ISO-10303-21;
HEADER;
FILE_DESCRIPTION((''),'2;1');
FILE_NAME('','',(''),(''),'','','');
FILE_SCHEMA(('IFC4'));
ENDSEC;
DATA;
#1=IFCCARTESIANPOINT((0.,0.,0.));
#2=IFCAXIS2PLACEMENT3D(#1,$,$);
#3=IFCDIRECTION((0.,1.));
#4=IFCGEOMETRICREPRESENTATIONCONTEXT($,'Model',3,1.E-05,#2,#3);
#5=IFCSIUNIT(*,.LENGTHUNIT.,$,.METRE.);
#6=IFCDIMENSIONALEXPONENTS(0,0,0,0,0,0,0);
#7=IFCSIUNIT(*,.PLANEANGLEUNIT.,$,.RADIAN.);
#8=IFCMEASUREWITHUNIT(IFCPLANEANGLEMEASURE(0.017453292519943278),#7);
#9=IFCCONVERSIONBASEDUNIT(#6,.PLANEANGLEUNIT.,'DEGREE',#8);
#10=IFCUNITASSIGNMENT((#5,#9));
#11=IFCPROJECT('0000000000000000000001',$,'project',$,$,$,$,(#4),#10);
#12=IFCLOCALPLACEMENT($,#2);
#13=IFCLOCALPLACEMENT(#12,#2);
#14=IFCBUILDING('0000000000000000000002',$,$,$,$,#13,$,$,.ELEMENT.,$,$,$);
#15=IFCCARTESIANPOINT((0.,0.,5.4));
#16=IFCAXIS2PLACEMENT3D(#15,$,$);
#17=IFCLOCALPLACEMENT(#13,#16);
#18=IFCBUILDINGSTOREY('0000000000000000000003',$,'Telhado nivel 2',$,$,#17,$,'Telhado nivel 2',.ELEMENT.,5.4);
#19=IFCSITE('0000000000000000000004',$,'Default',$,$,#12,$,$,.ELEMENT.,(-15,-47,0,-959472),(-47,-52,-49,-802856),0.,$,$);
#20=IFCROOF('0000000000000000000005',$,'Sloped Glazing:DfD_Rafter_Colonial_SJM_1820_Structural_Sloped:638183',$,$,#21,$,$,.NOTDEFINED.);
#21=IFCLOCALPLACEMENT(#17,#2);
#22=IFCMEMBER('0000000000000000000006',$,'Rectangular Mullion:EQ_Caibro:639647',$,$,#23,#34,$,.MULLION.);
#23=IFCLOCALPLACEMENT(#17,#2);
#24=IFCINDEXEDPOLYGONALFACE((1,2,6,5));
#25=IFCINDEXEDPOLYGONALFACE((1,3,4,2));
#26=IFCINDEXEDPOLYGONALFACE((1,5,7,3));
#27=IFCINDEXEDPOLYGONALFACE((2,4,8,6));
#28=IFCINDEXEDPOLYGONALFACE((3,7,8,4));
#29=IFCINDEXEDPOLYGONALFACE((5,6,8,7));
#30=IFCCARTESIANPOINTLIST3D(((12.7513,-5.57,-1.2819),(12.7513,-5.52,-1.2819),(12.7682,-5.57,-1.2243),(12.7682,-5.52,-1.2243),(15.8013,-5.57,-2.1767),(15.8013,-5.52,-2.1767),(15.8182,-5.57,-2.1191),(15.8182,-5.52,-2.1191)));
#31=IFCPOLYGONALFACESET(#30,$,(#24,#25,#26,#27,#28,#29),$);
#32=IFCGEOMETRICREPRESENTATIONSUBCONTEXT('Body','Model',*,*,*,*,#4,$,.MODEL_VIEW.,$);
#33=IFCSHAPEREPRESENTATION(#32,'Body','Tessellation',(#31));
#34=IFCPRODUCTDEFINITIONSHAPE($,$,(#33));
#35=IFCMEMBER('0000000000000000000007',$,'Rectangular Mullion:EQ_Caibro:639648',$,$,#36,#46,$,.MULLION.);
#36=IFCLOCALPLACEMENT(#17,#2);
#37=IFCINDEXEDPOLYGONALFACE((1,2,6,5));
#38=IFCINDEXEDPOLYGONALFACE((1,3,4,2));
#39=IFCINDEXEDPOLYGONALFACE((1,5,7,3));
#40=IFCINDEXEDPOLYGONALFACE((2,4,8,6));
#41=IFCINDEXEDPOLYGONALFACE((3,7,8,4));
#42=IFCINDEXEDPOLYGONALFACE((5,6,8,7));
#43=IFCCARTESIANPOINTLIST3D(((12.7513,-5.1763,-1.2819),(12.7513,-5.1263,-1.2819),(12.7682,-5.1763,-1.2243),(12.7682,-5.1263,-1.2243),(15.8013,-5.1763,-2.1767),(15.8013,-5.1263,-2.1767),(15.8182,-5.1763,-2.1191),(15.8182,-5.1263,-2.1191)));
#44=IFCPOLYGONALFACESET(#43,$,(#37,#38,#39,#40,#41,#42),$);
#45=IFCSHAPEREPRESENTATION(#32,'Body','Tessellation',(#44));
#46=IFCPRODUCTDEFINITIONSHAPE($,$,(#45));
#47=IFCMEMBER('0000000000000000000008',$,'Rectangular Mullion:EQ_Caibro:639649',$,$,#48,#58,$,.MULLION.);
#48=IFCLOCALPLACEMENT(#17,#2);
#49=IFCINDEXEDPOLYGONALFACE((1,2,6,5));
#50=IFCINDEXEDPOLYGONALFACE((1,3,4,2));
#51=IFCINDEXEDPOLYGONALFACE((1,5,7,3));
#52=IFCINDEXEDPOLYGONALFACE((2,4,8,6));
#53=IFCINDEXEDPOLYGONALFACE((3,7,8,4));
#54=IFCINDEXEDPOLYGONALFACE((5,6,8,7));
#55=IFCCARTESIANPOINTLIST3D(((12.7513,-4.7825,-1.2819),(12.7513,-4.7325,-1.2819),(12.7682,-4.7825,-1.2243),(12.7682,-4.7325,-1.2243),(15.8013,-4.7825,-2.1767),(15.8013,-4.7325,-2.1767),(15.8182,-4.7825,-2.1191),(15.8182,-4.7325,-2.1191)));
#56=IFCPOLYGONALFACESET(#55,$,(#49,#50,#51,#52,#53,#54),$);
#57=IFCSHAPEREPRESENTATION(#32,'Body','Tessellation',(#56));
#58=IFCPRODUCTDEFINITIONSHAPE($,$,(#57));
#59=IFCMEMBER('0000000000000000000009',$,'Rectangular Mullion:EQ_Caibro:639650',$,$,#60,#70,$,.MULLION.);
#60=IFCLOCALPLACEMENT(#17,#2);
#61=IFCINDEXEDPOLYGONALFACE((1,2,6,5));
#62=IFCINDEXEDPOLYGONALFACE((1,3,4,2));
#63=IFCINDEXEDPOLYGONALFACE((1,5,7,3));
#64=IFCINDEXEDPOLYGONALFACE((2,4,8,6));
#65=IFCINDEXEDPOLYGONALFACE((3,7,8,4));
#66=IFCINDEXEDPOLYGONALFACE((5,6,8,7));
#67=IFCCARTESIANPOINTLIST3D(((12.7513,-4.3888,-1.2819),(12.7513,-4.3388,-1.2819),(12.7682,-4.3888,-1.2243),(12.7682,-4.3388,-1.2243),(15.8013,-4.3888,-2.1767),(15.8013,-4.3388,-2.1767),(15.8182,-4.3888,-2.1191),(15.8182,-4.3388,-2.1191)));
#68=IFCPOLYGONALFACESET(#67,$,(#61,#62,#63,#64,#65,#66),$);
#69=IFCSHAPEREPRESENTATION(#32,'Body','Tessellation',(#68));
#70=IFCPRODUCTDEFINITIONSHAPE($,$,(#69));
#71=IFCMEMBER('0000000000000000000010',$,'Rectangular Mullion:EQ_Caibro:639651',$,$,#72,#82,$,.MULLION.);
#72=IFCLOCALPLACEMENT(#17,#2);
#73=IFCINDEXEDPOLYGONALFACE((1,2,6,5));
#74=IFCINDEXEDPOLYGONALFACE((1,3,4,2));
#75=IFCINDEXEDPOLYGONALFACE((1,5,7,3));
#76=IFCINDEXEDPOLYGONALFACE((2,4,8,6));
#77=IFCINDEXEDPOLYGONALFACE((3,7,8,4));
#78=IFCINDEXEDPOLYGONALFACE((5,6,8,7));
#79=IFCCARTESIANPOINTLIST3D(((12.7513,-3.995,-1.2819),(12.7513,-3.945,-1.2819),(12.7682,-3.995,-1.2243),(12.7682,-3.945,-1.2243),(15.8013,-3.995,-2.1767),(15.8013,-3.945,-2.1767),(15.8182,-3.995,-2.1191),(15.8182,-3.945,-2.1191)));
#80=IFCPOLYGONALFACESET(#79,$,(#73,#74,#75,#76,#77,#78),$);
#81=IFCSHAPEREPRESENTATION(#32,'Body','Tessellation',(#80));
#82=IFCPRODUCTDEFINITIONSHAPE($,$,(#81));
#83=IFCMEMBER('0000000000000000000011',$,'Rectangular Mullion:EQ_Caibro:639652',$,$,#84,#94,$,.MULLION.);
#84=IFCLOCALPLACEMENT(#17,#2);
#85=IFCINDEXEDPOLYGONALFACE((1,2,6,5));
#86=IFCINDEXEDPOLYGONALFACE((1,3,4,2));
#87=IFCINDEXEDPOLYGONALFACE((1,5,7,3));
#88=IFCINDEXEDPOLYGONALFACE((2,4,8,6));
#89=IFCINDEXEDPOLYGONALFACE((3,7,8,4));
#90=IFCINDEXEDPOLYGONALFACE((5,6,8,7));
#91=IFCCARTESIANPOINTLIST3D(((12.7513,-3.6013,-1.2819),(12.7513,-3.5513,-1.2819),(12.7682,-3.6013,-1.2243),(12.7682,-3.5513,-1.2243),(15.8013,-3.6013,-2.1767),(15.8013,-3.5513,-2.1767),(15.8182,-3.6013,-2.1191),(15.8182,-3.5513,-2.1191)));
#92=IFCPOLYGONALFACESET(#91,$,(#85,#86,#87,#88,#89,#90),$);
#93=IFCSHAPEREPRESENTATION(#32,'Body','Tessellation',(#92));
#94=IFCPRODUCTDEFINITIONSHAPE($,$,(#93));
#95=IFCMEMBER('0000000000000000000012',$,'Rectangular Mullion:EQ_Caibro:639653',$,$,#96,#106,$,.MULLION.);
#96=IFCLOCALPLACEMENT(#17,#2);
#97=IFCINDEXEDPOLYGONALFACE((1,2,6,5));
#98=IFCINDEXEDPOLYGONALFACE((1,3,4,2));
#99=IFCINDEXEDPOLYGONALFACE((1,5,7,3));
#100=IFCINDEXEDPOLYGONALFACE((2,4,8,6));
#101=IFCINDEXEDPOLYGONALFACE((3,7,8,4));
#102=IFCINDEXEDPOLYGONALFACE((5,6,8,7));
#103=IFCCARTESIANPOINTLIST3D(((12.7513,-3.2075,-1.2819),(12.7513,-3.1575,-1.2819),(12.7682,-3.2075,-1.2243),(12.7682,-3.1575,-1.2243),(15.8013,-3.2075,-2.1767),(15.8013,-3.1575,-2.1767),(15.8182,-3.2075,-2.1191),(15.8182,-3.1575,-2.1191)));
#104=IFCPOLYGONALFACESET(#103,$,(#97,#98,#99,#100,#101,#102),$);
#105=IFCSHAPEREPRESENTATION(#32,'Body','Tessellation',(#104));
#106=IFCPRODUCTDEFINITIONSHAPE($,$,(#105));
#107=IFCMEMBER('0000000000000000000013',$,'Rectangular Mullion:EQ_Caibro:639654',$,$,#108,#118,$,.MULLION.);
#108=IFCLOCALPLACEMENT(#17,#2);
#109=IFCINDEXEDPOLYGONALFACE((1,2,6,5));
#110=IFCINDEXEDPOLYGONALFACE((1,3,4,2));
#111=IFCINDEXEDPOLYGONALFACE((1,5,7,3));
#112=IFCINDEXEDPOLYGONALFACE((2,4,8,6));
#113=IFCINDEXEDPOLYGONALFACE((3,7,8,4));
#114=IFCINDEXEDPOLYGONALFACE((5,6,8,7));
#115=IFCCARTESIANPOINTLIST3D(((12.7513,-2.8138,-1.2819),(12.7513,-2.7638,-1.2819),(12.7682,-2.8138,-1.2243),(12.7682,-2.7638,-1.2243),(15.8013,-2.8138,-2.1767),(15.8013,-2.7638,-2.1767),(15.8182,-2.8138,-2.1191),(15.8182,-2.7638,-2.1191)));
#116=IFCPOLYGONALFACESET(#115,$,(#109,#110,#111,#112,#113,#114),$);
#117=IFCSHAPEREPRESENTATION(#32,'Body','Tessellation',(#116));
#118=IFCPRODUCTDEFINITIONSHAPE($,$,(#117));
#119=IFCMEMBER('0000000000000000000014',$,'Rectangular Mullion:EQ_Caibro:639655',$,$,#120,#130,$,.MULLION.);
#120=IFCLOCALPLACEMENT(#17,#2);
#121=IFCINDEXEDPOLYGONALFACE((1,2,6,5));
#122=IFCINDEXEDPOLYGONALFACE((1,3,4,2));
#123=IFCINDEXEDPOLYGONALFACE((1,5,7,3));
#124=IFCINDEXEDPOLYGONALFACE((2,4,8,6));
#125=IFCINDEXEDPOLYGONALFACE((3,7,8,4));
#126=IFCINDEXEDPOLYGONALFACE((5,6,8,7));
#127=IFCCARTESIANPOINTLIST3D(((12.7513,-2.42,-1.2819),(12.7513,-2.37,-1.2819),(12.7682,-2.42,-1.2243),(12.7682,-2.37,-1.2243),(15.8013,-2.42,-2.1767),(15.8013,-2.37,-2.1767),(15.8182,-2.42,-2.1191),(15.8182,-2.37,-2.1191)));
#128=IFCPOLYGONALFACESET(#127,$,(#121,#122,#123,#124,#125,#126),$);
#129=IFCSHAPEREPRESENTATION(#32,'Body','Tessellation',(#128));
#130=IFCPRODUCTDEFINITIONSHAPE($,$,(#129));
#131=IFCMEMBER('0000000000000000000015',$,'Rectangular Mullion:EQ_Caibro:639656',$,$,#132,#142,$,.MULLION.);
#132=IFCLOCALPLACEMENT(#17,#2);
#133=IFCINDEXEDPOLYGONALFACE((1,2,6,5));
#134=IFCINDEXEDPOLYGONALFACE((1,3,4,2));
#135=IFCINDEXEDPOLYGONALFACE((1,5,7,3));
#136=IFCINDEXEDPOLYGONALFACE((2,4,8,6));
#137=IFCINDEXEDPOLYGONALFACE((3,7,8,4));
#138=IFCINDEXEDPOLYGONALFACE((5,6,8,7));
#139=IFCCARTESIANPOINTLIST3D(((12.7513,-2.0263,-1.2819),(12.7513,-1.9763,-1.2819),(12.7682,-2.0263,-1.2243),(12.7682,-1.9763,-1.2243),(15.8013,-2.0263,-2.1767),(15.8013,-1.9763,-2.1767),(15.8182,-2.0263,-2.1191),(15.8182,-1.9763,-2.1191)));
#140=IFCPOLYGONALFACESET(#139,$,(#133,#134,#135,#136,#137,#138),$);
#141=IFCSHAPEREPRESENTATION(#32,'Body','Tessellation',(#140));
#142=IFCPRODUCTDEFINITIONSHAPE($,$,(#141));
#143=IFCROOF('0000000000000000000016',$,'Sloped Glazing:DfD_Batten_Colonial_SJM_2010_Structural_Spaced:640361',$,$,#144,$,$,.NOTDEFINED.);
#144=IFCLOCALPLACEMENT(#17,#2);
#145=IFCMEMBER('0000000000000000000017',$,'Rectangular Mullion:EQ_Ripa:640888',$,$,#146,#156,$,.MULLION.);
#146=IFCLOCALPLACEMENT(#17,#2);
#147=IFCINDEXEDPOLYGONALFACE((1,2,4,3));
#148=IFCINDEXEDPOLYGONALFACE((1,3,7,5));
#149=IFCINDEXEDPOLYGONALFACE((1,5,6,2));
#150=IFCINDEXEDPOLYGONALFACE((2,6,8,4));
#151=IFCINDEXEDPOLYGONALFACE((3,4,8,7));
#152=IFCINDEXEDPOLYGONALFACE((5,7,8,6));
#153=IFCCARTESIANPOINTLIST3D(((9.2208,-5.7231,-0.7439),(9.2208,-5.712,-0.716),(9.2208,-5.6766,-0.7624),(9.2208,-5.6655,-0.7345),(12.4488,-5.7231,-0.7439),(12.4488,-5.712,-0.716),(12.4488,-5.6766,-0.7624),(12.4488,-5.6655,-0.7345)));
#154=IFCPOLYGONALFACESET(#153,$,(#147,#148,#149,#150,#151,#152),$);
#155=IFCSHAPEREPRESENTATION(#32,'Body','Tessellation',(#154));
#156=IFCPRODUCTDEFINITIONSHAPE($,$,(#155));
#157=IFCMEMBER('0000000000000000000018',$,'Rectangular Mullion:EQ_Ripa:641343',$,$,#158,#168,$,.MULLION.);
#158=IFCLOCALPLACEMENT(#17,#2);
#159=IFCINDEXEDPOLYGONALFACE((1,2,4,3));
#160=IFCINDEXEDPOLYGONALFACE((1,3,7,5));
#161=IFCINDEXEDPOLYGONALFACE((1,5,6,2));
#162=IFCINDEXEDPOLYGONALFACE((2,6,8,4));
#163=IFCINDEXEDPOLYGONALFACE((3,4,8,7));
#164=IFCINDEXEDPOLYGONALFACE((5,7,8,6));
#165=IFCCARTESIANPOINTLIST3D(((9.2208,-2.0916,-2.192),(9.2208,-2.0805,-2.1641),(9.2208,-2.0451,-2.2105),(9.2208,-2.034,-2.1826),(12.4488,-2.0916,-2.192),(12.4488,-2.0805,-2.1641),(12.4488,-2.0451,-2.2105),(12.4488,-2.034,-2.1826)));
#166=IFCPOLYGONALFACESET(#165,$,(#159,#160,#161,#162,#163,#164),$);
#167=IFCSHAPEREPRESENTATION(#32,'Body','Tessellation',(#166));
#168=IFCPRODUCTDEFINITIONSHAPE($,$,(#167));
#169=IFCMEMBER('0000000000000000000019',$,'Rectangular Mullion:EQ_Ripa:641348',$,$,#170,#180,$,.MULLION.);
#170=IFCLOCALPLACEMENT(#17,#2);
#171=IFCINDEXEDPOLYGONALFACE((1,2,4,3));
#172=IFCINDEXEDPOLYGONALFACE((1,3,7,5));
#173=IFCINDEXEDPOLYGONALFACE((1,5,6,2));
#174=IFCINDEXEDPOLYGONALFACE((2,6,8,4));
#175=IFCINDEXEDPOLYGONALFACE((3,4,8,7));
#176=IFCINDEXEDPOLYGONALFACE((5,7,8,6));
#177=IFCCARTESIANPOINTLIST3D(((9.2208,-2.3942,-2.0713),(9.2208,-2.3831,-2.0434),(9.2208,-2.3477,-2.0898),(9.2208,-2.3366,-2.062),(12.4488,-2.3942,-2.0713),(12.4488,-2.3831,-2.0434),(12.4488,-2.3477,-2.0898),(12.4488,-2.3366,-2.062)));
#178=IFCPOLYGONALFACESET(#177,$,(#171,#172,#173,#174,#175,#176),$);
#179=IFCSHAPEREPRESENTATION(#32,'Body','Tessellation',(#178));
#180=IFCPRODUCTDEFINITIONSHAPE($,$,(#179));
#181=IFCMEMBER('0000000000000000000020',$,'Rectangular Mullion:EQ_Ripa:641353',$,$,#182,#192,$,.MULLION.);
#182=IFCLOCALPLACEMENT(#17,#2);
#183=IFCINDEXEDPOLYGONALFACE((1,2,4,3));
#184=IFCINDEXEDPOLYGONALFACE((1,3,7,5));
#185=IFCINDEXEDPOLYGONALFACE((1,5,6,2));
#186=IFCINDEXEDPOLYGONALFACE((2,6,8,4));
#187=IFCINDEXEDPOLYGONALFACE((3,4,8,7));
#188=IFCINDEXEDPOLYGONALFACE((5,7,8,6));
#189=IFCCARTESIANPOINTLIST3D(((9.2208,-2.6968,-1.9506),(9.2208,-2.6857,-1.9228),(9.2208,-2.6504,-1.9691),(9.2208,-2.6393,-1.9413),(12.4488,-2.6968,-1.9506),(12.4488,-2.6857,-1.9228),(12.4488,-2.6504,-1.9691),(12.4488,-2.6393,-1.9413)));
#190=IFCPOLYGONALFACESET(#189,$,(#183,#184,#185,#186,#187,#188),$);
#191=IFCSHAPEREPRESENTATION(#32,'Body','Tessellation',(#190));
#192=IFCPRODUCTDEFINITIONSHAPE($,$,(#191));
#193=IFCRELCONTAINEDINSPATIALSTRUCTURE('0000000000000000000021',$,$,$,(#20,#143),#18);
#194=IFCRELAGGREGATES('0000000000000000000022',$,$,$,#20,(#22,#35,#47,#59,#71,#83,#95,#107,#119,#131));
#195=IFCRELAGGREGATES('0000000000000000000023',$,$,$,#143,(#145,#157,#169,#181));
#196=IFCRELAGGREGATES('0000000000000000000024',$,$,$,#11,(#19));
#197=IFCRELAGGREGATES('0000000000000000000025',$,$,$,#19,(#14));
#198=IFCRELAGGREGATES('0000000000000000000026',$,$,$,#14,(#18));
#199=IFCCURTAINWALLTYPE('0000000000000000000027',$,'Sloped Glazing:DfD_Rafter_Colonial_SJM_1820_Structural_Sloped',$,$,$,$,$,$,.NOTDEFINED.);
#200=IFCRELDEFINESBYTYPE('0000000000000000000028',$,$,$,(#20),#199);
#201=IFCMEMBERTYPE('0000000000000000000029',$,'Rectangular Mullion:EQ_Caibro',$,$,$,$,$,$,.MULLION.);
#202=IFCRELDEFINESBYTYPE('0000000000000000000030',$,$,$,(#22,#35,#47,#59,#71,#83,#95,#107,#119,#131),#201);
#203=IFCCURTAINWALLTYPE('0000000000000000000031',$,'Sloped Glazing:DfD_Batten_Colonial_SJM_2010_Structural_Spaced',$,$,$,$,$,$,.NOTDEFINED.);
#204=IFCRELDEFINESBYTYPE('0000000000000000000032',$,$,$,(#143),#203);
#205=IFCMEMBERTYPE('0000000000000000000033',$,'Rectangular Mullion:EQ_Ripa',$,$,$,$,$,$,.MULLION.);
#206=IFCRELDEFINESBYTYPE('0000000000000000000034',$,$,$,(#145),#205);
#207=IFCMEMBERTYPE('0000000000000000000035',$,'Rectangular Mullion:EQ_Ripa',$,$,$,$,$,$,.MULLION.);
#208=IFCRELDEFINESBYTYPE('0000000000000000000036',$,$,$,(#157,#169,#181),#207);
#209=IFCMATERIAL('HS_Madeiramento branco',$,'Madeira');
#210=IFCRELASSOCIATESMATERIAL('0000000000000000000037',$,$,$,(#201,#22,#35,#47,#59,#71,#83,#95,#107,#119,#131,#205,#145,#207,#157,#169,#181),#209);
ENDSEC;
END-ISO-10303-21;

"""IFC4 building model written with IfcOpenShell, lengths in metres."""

from ifc_helpers import new_model, entity, si_unit, converted_unit, direction, frame, origin, place, context, subcontext, project, spatial, indexed_curve, outline, extrude, source, transform, mapped, material, type_object, type_shapes, element, aggregate, save


model = new_model("IFC4")

# Units and contexts
model_context = context("Model", 3, precision=1e-05, world=origin(), true_north=direction((0.0, 1.0)))
body_context = subcontext(model_context, "Body", "Model", "MODEL_VIEW")
ifc_project = project(units=[si_unit("LENGTHUNIT", "METRE"), converted_unit("PLANEANGLEUNIT", "DEGREE", entity("IfcPlaneAngleMeasure", 0.017453292519943278), si_unit("PLANEANGLEUNIT", "RADIAN"), dimensions=[0, 0, 0, 0, 0, 0, 0])], contexts=[model_context])

# Site, building, storey
site_placement = place(None, origin())
site = spatial("IfcSite", under=ifc_project, at=site_placement, Name="Default", CompositionType="ELEMENT", RefLatitude=(-15, -47, 0, -959472), RefLongitude=(-47, -52, -49, -802856), RefElevation=0.0)
building_placement = place(site_placement, origin())
building = spatial("IfcBuilding", under=site, at=building_placement, CompositionType="ELEMENT")
storey_placement = place(building_placement, frame((0.0, 0.0, 5.4)))
storey = spatial("IfcBuildingStorey", under=building, at=storey_placement, Name="Telhado nivel 2", LongName="Telhado nivel 2", CompositionType="ELEMENT", Elevation=5.4)

# Roofs, members
curtain_wall_type_1 = type_object("IfcCurtainWallType", Name="Sloped Glazing:DfD_Rafter_Colonial_SJM_1820_Structural_Sloped", PredefinedType="NOTDEFINED")
roof_1_placement = place(storey_placement, frame((0.0, 0.0, -5.4)))
roof_1 = element("IfcRoof", 1, at=roof_1_placement, inside=storey, type_object=curtain_wall_type_1, Name="Sloped Glazing:DfD_Rafter_Colonial_SJM_1820_Structural_Sloped:638183", PredefinedType="NOTDEFINED")
ifc_material = material(Name="HS_Madeiramento branco", Category="Madeira")
member_type_1 = type_object("IfcMemberType", Name="Rectangular Mullion:EQ_Caibro", PredefinedType="MULLION", material=ifc_material)
shared_shape_1 = source(origin(), body_context, "Body", "SweptSolid", [
    extrude(outline(indexed_curve([(-0.025, -0.03), (0.025, -0.03), (0.025, 0.03), (-0.025, 0.03), (-0.025, -0.03)], self_intersect=False)), frame((0.0, -0.03, -3.1785), z_axis=(0.0, 0.0, 1.0), x_axis=(-1.0, 0.0, 0.0)), (0.0, 0.0, 1.0), 3.1785),
])
type_shapes(member_type_1, [shared_shape_1])
member_1_placement = place(roof_1_placement, frame((12.7513, -5.545, 4.1181), z_axis=(-0.95956, 0.0, 0.281504), x_axis=(0.0, 1.0, 0.0)))
member_1 = element("IfcMember", 2, at=member_1_placement, type_object=member_type_1, material=ifc_material, Name="Rectangular Mullion:EQ_Caibro:639647", PredefinedType="MULLION", context=body_context, shape_type="MappedRepresentation", body=[
    mapped(shared_shape_1, transform((0.0, 0.0, 0.0), scale=1.0)),
])
member_2_placement = place(roof_1_placement, frame((12.7513, -5.1513, 4.1181), z_axis=(-0.95956, 0.0, 0.281504), x_axis=(0.0, 1.0, 0.0)))
member_2 = element("IfcMember", 3, at=member_2_placement, type_object=member_type_1, material=ifc_material, Name="Rectangular Mullion:EQ_Caibro:639648", PredefinedType="MULLION", context=body_context, shape_type="MappedRepresentation", body=[
    mapped(shared_shape_1, transform((0.0, 0.0, 0.0), scale=1.0)),
])
member_3_placement = place(roof_1_placement, frame((12.7513, -4.7575, 4.1181), z_axis=(-0.95956, 0.0, 0.281504), x_axis=(0.0, 1.0, 0.0)))
member_3 = element("IfcMember", 4, at=member_3_placement, type_object=member_type_1, material=ifc_material, Name="Rectangular Mullion:EQ_Caibro:639649", PredefinedType="MULLION", context=body_context, shape_type="MappedRepresentation", body=[
    mapped(shared_shape_1, transform((0.0, 0.0, 0.0), scale=1.0)),
])
member_4_placement = place(roof_1_placement, frame((12.7513, -4.3638, 4.1181), z_axis=(-0.95956, 0.0, 0.281504), x_axis=(0.0, 1.0, 0.0)))
member_4 = element("IfcMember", 5, at=member_4_placement, type_object=member_type_1, material=ifc_material, Name="Rectangular Mullion:EQ_Caibro:639650", PredefinedType="MULLION", context=body_context, shape_type="MappedRepresentation", body=[
    mapped(shared_shape_1, transform((0.0, 0.0, 0.0), scale=1.0)),
])
member_5_placement = place(roof_1_placement, frame((12.7513, -3.97, 4.1181), z_axis=(-0.95956, 0.0, 0.281504), x_axis=(0.0, 1.0, 0.0)))
member_5 = element("IfcMember", 6, at=member_5_placement, type_object=member_type_1, material=ifc_material, Name="Rectangular Mullion:EQ_Caibro:639651", PredefinedType="MULLION", context=body_context, shape_type="MappedRepresentation", body=[
    mapped(shared_shape_1, transform((0.0, 0.0, 0.0), scale=1.0)),
])
member_6_placement = place(roof_1_placement, frame((12.7513, -3.5763, 4.1181), z_axis=(-0.95956, 0.0, 0.281504), x_axis=(0.0, 1.0, 0.0)))
member_6 = element("IfcMember", 7, at=member_6_placement, type_object=member_type_1, material=ifc_material, Name="Rectangular Mullion:EQ_Caibro:639652", PredefinedType="MULLION", context=body_context, shape_type="MappedRepresentation", body=[
    mapped(shared_shape_1, transform((0.0, 0.0, 0.0), scale=1.0)),
])
member_7_placement = place(roof_1_placement, frame((12.7513, -3.1825, 4.1181), z_axis=(-0.95956, 0.0, 0.281504), x_axis=(0.0, 1.0, 0.0)))
member_7 = element("IfcMember", 8, at=member_7_placement, type_object=member_type_1, material=ifc_material, Name="Rectangular Mullion:EQ_Caibro:639653", PredefinedType="MULLION", context=body_context, shape_type="MappedRepresentation", body=[
    mapped(shared_shape_1, transform((0.0, 0.0, 0.0), scale=1.0)),
])
member_8_placement = place(roof_1_placement, frame((12.7513, -2.7888, 4.1181), z_axis=(-0.95956, 0.0, 0.281504), x_axis=(0.0, 1.0, 0.0)))
member_8 = element("IfcMember", 9, at=member_8_placement, type_object=member_type_1, material=ifc_material, Name="Rectangular Mullion:EQ_Caibro:639654", PredefinedType="MULLION", context=body_context, shape_type="MappedRepresentation", body=[
    mapped(shared_shape_1, transform((0.0, 0.0, 0.0), scale=1.0)),
])
member_9_placement = place(roof_1_placement, frame((12.7513, -2.395, 4.1181), z_axis=(-0.95956, 0.0, 0.281504), x_axis=(0.0, 1.0, 0.0)))
member_9 = element("IfcMember", 10, at=member_9_placement, type_object=member_type_1, material=ifc_material, Name="Rectangular Mullion:EQ_Caibro:639655", PredefinedType="MULLION", context=body_context, shape_type="MappedRepresentation", body=[
    mapped(shared_shape_1, transform((0.0, 0.0, 0.0), scale=1.0)),
])
member_10_placement = place(roof_1_placement, frame((12.7513, -2.0013, 4.1181), z_axis=(-0.95956, 0.0, 0.281504), x_axis=(0.0, 1.0, 0.0)))
member_10 = element("IfcMember", 11, at=member_10_placement, type_object=member_type_1, material=ifc_material, Name="Rectangular Mullion:EQ_Caibro:639656", PredefinedType="MULLION", context=body_context, shape_type="MappedRepresentation", body=[
    mapped(shared_shape_1, transform((0.0, 0.0, 0.0), scale=1.0)),
])
aggregate(roof_1, [member_1, member_2, member_3, member_4, member_5, member_6, member_7, member_8, member_9, member_10])
curtain_wall_type_2 = type_object("IfcCurtainWallType", Name="Sloped Glazing:DfD_Batten_Colonial_SJM_2010_Structural_Spaced", PredefinedType="NOTDEFINED")
roof_2_placement = place(storey_placement, frame((0.0, 0.0, -5.4)))
roof_2 = element("IfcRoof", 12, at=roof_2_placement, inside=storey, type_object=curtain_wall_type_2, Name="Sloped Glazing:DfD_Batten_Colonial_SJM_2010_Structural_Spaced:640361", PredefinedType="NOTDEFINED")
member_type_2 = type_object("IfcMemberType", Name="Rectangular Mullion:EQ_Ripa", PredefinedType="MULLION", material=ifc_material)
shared_shape_2 = source(origin(), body_context, "Body", "SweptSolid", [
    extrude(outline(indexed_curve([(-0.025, -0.015), (0.025, -0.015), (0.025, 0.015), (-0.025, 0.015), (-0.025, -0.015)], self_intersect=False)), frame((-0.025, 0.0, -3.228), z_axis=(0.0, 0.0, 1.0), x_axis=(-1.0, 0.0, 0.0)), (0.0, 0.0, 1.0), 3.228),
])
type_shapes(member_type_2, [shared_shape_2])
member_11_placement = place(roof_2_placement, frame((12.4488, -5.7175, 4.6701), z_axis=(1.0, 0.0, 0.0), x_axis=(0.0, -0.928874, 0.370395)))
member_11 = element("IfcMember", 13, at=member_11_placement, type_object=member_type_2, material=ifc_material, Name="Rectangular Mullion:EQ_Ripa:640888", PredefinedType="MULLION", context=body_context, shape_type="MappedRepresentation", body=[
    mapped(shared_shape_2, transform((0.0, 0.0, 0.0), scale=1.0)),
])
member_type_3 = type_object("IfcMemberType", Name="Rectangular Mullion:EQ_Ripa", PredefinedType="MULLION", material=ifc_material)
shared_shape_3 = source(origin(), body_context, "Body", "SweptSolid", [
    extrude(outline(indexed_curve([(-0.025, -0.015), (0.025, -0.015), (0.025, 0.015), (-0.025, 0.015), (-0.025, -0.015)], self_intersect=False)), frame((0.0, 0.0, -3.228), z_axis=(0.0, 0.0, 1.0), x_axis=(-1.0, 0.0, 0.0)), (0.0, 0.0, 1.0), 3.228),
])
type_shapes(member_type_3, [shared_shape_3])
member_12_placement = place(roof_2_placement, frame((12.4488, -2.0628, 3.2127), z_axis=(1.0, 0.0, 0.0), x_axis=(0.0, -0.928874, 0.370395)))
member_12 = element("IfcMember", 14, at=member_12_placement, type_object=member_type_3, material=ifc_material, Name="Rectangular Mullion:EQ_Ripa:641343", PredefinedType="MULLION", context=body_context, shape_type="MappedRepresentation", body=[
    mapped(shared_shape_3, transform((0.0, 0.0, 0.0), scale=1.0)),
])
member_13_placement = place(roof_2_placement, frame((12.4488, -2.3654, 3.3334), z_axis=(1.0, 0.0, 0.0), x_axis=(0.0, -0.928874, 0.370395)))
member_13 = element("IfcMember", 15, at=member_13_placement, type_object=member_type_3, material=ifc_material, Name="Rectangular Mullion:EQ_Ripa:641348", PredefinedType="MULLION", context=body_context, shape_type="MappedRepresentation", body=[
    mapped(shared_shape_3, transform((0.0, 0.0, 0.0), scale=1.0)),
])
member_14_placement = place(roof_2_placement, frame((12.4488, -2.668, 3.454), z_axis=(1.0, 0.0, 0.0), x_axis=(0.0, -0.928874, 0.370395)))
member_14 = element("IfcMember", 16, at=member_14_placement, type_object=member_type_3, material=ifc_material, Name="Rectangular Mullion:EQ_Ripa:641353", PredefinedType="MULLION", context=body_context, shape_type="MappedRepresentation", body=[
    mapped(shared_shape_3, transform((0.0, 0.0, 0.0), scale=1.0)),
])
aggregate(roof_2, [member_11, member_12, member_13, member_14])

save(model, "model.ifc")
